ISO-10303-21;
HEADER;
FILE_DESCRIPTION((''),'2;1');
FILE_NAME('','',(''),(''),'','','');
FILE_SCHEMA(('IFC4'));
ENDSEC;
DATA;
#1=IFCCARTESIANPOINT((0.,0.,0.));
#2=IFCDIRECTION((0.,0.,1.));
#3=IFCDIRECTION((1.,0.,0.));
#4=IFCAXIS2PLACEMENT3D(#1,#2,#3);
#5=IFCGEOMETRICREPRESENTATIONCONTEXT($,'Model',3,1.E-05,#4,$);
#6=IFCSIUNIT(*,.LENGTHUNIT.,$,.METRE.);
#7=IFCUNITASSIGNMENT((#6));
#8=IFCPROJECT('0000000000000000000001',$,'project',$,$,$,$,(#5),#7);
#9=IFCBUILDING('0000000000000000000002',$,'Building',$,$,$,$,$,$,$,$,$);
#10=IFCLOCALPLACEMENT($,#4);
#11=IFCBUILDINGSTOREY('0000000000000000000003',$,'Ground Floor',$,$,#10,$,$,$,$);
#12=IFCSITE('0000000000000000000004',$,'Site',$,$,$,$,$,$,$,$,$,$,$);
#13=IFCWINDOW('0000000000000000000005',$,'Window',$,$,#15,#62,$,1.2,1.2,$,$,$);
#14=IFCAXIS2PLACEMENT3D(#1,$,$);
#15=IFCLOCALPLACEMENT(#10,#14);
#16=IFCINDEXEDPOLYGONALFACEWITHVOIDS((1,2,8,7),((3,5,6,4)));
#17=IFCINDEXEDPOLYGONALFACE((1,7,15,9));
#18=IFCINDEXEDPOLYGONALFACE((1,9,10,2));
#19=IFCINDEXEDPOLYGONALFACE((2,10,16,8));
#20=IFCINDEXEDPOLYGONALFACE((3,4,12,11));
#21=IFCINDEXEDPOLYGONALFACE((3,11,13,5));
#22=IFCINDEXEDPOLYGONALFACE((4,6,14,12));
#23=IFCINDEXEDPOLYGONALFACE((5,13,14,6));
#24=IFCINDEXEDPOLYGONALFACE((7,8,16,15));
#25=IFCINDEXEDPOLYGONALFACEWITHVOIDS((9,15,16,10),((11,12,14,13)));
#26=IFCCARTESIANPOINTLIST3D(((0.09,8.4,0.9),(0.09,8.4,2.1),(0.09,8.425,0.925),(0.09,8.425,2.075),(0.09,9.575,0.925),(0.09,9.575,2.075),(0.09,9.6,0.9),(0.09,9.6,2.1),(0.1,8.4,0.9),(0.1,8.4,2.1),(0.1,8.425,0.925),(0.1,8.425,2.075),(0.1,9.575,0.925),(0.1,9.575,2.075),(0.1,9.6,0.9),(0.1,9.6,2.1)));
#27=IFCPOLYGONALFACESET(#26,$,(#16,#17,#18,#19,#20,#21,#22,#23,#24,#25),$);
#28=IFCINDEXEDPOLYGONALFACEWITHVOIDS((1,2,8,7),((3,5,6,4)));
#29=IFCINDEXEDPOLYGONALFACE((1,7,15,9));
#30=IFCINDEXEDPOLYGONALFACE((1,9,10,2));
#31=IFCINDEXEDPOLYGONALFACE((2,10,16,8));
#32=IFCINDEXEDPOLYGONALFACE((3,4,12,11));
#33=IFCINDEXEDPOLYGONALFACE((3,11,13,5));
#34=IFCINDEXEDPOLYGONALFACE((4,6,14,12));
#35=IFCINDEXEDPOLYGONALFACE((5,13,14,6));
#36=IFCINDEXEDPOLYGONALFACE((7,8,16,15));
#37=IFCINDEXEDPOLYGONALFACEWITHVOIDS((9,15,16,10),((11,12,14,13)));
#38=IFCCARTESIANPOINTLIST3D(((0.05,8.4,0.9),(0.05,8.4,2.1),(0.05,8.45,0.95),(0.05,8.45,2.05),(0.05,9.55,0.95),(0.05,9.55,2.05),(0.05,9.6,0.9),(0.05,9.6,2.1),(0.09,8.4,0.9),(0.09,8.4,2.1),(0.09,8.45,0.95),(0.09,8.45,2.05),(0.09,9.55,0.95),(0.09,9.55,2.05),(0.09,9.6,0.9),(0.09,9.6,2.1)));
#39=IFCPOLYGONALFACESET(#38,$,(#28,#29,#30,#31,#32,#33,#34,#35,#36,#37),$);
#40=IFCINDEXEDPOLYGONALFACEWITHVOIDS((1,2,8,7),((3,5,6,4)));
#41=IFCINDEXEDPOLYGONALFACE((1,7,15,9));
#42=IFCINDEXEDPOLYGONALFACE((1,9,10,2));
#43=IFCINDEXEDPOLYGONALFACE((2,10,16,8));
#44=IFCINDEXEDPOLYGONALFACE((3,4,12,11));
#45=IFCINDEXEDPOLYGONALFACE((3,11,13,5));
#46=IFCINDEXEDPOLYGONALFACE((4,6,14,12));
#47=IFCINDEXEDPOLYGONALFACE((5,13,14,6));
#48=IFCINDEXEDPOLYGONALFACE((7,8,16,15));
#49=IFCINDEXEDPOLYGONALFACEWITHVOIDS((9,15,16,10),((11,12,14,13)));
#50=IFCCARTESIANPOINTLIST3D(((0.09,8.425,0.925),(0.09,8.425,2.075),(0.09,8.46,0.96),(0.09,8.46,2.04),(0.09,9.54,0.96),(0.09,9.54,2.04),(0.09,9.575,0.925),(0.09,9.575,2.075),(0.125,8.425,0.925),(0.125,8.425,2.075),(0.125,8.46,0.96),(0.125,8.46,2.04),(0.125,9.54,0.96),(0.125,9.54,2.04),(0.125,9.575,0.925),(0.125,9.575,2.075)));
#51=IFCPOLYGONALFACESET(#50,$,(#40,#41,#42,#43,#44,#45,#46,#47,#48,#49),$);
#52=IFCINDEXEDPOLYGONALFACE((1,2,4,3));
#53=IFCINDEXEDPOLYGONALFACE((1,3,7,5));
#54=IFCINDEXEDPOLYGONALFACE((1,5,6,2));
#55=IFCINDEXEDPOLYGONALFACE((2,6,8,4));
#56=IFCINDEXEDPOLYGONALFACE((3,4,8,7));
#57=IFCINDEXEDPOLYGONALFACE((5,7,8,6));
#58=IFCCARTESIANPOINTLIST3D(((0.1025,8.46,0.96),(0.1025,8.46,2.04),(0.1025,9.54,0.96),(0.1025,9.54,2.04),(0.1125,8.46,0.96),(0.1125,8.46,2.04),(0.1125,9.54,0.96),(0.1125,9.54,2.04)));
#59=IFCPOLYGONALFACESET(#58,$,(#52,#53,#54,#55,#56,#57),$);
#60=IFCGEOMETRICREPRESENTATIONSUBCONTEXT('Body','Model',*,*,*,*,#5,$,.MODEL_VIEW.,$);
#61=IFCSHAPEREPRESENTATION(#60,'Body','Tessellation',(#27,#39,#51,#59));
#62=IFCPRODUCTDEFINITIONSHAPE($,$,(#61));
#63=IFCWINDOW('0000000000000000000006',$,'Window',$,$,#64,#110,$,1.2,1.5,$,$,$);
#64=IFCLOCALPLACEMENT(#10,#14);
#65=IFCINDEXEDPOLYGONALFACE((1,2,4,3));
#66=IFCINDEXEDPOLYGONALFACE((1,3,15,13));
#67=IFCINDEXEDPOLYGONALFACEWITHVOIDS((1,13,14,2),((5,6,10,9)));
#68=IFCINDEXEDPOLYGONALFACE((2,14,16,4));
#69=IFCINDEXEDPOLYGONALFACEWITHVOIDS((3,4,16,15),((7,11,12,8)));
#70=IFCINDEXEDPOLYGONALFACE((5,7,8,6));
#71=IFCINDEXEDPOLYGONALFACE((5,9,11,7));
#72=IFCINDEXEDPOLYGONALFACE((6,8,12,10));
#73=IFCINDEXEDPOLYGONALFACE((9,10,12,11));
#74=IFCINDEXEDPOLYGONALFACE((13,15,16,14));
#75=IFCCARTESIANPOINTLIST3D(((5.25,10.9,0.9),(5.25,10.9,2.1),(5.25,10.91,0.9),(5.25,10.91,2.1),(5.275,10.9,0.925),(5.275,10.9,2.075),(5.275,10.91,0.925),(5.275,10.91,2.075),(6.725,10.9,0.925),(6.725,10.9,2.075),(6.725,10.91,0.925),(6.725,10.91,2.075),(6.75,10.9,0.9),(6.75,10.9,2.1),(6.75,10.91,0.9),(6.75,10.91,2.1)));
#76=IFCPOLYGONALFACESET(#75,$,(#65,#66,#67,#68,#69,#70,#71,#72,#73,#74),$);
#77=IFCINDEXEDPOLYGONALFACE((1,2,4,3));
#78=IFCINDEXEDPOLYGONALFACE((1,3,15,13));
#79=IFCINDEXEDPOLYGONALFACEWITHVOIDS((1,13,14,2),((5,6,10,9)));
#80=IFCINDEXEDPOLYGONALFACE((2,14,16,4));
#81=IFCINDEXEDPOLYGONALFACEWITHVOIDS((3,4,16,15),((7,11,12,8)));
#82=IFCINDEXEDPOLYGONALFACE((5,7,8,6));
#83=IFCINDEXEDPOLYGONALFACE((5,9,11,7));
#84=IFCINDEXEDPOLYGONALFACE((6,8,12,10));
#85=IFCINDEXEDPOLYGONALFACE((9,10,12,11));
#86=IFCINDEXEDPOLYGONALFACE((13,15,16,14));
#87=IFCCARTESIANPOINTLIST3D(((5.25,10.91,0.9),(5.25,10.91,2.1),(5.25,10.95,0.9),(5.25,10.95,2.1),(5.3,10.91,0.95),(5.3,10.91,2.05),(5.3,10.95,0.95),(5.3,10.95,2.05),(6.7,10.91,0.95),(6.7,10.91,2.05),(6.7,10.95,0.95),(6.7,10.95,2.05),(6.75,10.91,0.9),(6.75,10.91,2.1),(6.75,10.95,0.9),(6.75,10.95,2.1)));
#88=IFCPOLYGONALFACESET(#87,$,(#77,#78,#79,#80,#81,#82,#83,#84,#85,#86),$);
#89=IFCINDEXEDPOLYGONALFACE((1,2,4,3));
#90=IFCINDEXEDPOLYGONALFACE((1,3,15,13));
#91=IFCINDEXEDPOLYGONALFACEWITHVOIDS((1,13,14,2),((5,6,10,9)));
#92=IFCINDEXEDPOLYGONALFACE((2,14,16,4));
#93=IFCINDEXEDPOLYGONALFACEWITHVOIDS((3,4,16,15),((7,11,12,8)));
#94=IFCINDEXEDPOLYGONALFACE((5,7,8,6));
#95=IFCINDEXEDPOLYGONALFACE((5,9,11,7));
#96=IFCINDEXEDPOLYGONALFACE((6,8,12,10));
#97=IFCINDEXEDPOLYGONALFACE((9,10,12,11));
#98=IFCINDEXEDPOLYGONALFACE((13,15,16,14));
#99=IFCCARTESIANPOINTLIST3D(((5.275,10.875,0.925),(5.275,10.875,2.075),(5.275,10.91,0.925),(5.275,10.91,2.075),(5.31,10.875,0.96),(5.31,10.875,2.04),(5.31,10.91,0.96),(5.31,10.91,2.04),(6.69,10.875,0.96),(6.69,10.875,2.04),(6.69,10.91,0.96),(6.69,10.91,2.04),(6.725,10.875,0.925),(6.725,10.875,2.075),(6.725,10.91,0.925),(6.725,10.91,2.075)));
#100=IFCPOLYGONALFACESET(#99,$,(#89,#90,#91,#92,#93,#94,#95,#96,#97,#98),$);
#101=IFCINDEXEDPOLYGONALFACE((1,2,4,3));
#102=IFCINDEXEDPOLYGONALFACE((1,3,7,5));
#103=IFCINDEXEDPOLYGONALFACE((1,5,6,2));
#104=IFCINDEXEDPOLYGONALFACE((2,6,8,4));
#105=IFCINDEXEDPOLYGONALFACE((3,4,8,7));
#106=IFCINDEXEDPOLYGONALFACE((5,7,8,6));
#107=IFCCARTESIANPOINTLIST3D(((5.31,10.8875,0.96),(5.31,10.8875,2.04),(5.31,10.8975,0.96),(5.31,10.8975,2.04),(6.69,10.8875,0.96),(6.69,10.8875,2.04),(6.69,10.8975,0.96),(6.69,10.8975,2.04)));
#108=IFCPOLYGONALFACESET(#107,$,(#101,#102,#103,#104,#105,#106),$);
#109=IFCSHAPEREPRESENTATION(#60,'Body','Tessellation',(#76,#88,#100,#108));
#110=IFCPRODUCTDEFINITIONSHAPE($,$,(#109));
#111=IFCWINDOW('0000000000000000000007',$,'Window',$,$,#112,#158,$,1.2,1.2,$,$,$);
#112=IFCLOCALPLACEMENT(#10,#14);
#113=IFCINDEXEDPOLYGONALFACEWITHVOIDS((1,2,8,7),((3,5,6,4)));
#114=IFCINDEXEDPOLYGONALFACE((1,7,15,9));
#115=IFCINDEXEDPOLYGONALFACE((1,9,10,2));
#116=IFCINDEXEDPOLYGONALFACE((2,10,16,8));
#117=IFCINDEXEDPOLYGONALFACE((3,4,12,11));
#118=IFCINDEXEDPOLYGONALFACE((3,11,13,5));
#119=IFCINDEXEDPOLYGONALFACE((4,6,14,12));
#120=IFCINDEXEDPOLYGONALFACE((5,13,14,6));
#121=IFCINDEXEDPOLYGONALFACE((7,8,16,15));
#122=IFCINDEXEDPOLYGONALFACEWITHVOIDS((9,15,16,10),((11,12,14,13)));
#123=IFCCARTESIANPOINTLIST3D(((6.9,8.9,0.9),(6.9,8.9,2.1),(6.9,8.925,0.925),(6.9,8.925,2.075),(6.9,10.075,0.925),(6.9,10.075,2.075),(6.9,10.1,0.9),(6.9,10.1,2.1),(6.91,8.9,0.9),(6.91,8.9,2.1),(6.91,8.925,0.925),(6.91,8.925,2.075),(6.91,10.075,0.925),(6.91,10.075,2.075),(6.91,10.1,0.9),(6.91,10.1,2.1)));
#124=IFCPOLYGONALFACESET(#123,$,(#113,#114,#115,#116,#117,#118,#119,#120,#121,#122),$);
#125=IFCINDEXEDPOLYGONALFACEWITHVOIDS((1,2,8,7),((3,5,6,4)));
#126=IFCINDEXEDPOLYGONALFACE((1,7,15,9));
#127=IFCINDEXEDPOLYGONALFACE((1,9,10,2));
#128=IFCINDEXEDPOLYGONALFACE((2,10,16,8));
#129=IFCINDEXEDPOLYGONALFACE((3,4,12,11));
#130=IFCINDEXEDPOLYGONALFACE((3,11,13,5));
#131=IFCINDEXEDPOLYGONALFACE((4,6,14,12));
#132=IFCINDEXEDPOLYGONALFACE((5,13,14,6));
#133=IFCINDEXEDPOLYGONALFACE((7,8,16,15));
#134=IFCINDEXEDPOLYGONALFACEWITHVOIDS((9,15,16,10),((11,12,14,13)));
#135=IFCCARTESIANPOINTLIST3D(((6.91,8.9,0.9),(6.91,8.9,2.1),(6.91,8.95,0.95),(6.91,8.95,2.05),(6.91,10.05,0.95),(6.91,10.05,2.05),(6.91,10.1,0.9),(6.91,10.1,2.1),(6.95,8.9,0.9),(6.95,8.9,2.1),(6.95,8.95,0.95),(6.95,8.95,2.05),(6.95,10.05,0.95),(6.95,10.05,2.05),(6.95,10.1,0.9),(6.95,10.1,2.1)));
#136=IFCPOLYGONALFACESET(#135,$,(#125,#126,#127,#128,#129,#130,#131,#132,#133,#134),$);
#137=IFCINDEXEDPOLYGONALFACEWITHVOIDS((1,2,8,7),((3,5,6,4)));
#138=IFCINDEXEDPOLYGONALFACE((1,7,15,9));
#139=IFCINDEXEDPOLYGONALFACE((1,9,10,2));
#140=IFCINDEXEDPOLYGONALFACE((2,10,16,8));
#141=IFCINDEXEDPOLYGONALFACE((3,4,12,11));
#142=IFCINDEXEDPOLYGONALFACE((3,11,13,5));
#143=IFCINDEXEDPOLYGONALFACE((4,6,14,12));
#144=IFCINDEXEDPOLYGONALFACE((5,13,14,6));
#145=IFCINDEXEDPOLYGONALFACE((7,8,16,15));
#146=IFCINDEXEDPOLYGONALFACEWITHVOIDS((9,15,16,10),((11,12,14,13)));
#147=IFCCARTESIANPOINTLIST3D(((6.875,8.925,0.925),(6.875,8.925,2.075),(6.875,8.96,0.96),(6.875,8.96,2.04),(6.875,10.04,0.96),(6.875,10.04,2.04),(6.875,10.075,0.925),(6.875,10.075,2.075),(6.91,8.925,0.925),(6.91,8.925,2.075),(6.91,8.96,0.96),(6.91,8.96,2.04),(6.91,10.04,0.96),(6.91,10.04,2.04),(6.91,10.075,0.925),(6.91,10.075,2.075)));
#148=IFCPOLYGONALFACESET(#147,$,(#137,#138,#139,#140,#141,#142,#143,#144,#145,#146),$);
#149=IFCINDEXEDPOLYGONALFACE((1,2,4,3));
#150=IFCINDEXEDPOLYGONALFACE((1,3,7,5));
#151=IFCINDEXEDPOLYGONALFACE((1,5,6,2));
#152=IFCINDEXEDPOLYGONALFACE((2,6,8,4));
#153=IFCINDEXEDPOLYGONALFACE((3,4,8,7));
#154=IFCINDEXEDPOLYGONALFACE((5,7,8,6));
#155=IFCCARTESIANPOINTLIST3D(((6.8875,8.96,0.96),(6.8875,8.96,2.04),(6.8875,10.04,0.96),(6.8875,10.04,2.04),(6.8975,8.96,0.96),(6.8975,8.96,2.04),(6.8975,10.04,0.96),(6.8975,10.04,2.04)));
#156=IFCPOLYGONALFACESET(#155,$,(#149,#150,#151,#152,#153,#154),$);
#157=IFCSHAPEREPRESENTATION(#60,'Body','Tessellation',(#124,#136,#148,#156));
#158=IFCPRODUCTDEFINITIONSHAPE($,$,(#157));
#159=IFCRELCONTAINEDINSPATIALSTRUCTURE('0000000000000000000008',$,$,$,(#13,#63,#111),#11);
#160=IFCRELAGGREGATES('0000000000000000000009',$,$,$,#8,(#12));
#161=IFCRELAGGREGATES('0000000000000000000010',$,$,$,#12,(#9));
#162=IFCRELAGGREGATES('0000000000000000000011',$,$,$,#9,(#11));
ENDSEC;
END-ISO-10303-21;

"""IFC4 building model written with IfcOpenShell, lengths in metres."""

from ifc_helpers import new_model, si_unit, frame, origin_with_axes, place, context, subcontext, project, spatial, line, indexed_curve, outline, extrude, element, save


model = new_model("IFC4")

# Units and contexts
model_context = context("Model", 3, precision=1e-05, world=origin_with_axes())
body_context = subcontext(model_context, "Body", "Model", "MODEL_VIEW")
ifc_project = project(units=[si_unit("LENGTHUNIT", "METRE")], contexts=[model_context])

# Site, building, storey
site = spatial("IfcSite", under=ifc_project, Name="Site")
building = spatial("IfcBuilding", under=site, Name="Building")
storey_placement = place(None, origin_with_axes())
storey = spatial("IfcBuildingStorey", under=building, at=storey_placement, Name="Ground Floor")

# Windows
window_1_placement = place(storey_placement, frame((0.0, 9.6, 0.9), z_axis=(0.0, 0.0, 1.0), x_axis=(0.0, -1.0, 0.0)))
element("IfcWindow", 1, at=window_1_placement, inside=storey, Name="Window", OverallHeight=1.2, OverallWidth=1.2, context=body_context, shape_type="SweptSolid", body=[
    extrude(outline(indexed_curve([(0.0, 0.0), (1.2, 0.0), (1.2, 1.2), (0.0, 1.2)], segments=[line(1, 2, 3, 4, 1)]), holes=[indexed_curve([(0.025, 0.025), (1.175, 0.025), (1.175, 1.175), (0.025, 1.175)], segments=[line(1, 2, 3, 4, 1)])]), frame((0.0, 0.09, 0.0), z_axis=(0.0, -1.0, 0.0), x_axis=(1.0, 0.0, 0.0)), (0.0, 0.0, -1.0), 0.01),
    extrude(outline(indexed_curve([(0.0, 0.0), (1.2, 0.0), (1.2, 1.2), (0.0, 1.2)], segments=[line(1, 2, 3, 4, 1)]), holes=[indexed_curve([(0.05, 0.05), (1.15, 0.05), (1.15, 1.15), (0.05, 1.15)], segments=[line(1, 2, 3, 4, 1)])]), frame((0.0, 0.05, 0.0), z_axis=(0.0, -1.0, 0.0), x_axis=(1.0, 0.0, 0.0)), (0.0, 0.0, -1.0), 0.04),
    extrude(outline(indexed_curve([(0.0, 0.0), (1.15, 0.0), (1.15, 1.15), (0.0, 1.15)], segments=[line(1, 2, 3, 4, 1)]), holes=[indexed_curve([(0.035, 0.035), (1.115, 0.035), (1.115, 1.115), (0.035, 1.115)], segments=[line(1, 2, 3, 4, 1)])]), frame((0.025, 0.09, 0.025), z_axis=(0.0, -1.0, 0.0), x_axis=(1.0, 0.0, 0.0)), (0.0, 0.0, -1.0), 0.035),
    extrude(outline(indexed_curve([(0.035, 0.035), (1.115, 0.035), (1.115, 1.115), (0.035, 1.115)], segments=[line(1, 2, 3, 4, 1)])), frame((0.025, 0.1025, 0.025), z_axis=(0.0, -1.0, 0.0), x_axis=(1.0, 0.0, 0.0)), (0.0, 0.0, -1.0), 0.01),
])
window_2_placement = place(storey_placement, frame((6.75, 11.0, 0.9), z_axis=(0.0, 0.0, 1.0), x_axis=(-1.0, 0.0, 0.0)))
element("IfcWindow", 2, at=window_2_placement, inside=storey, Name="Window", OverallHeight=1.2, OverallWidth=1.5, context=body_context, shape_type="SweptSolid", body=[
    extrude(outline(indexed_curve([(0.0, 0.0), (1.5, 0.0), (1.5, 1.2), (0.0, 1.2)], segments=[line(1, 2, 3, 4, 1)]), holes=[indexed_curve([(0.025, 0.025), (1.475, 0.025), (1.475, 1.175), (0.025, 1.175)], segments=[line(1, 2, 3, 4, 1)])]), frame((0.0, 0.09, 0.0), z_axis=(0.0, -1.0, 0.0), x_axis=(1.0, 0.0, 0.0)), (0.0, 0.0, -1.0), 0.01),
    extrude(outline(indexed_curve([(0.0, 0.0), (1.5, 0.0), (1.5, 1.2), (0.0, 1.2)], segments=[line(1, 2, 3, 4, 1)]), holes=[indexed_curve([(0.05, 0.05), (1.45, 0.05), (1.45, 1.15), (0.05, 1.15)], segments=[line(1, 2, 3, 4, 1)])]), frame((0.0, 0.05, 0.0), z_axis=(0.0, -1.0, 0.0), x_axis=(1.0, 0.0, 0.0)), (0.0, 0.0, -1.0), 0.04),
    extrude(outline(indexed_curve([(0.0, 0.0), (1.45, 0.0), (1.45, 1.15), (0.0, 1.15)], segments=[line(1, 2, 3, 4, 1)]), holes=[indexed_curve([(0.035, 0.035), (1.415, 0.035), (1.415, 1.115), (0.035, 1.115)], segments=[line(1, 2, 3, 4, 1)])]), frame((0.025, 0.09, 0.025), z_axis=(0.0, -1.0, 0.0), x_axis=(1.0, 0.0, 0.0)), (0.0, 0.0, -1.0), 0.035),
    extrude(outline(indexed_curve([(0.035, 0.035), (1.415, 0.035), (1.415, 1.115), (0.035, 1.115)], segments=[line(1, 2, 3, 4, 1)])), frame((0.025, 0.1025, 0.025), z_axis=(0.0, -1.0, 0.0), x_axis=(1.0, 0.0, 0.0)), (0.0, 0.0, -1.0), 0.01),
])
window_3_placement = place(storey_placement, frame((7.0, 8.9, 0.9), z_axis=(0.0, 0.0, 1.0), x_axis=(0.0, 1.0, 0.0)))
element("IfcWindow", 3, at=window_3_placement, inside=storey, Name="Window", OverallHeight=1.2, OverallWidth=1.2, context=body_context, shape_type="SweptSolid", body=[
    extrude(outline(indexed_curve([(0.0, 0.0), (1.2, 0.0), (1.2, 1.2), (0.0, 1.2)], segments=[line(1, 2, 3, 4, 1)]), holes=[indexed_curve([(0.025, 0.025), (1.175, 0.025), (1.175, 1.175), (0.025, 1.175)], segments=[line(1, 2, 3, 4, 1)])]), frame((0.0, 0.09, 0.0), z_axis=(0.0, -1.0, 0.0), x_axis=(1.0, 0.0, 0.0)), (0.0, 0.0, -1.0), 0.01),
    extrude(outline(indexed_curve([(0.0, 0.0), (1.2, 0.0), (1.2, 1.2), (0.0, 1.2)], segments=[line(1, 2, 3, 4, 1)]), holes=[indexed_curve([(0.05, 0.05), (1.15, 0.05), (1.15, 1.15), (0.05, 1.15)], segments=[line(1, 2, 3, 4, 1)])]), frame((0.0, 0.05, 0.0), z_axis=(0.0, -1.0, 0.0), x_axis=(1.0, 0.0, 0.0)), (0.0, 0.0, -1.0), 0.04),
    extrude(outline(indexed_curve([(0.0, 0.0), (1.15, 0.0), (1.15, 1.15), (0.0, 1.15)], segments=[line(1, 2, 3, 4, 1)]), holes=[indexed_curve([(0.035, 0.035), (1.115, 0.035), (1.115, 1.115), (0.035, 1.115)], segments=[line(1, 2, 3, 4, 1)])]), frame((0.025, 0.09, 0.025), z_axis=(0.0, -1.0, 0.0), x_axis=(1.0, 0.0, 0.0)), (0.0, 0.0, -1.0), 0.035),
    extrude(outline(indexed_curve([(0.035, 0.035), (1.115, 0.035), (1.115, 1.115), (0.035, 1.115)], segments=[line(1, 2, 3, 4, 1)])), frame((0.025, 0.1025, 0.025), z_axis=(0.0, -1.0, 0.0), x_axis=(1.0, 0.0, 0.0)), (0.0, 0.0, -1.0), 0.01),
])

save(model, "model.ifc")
